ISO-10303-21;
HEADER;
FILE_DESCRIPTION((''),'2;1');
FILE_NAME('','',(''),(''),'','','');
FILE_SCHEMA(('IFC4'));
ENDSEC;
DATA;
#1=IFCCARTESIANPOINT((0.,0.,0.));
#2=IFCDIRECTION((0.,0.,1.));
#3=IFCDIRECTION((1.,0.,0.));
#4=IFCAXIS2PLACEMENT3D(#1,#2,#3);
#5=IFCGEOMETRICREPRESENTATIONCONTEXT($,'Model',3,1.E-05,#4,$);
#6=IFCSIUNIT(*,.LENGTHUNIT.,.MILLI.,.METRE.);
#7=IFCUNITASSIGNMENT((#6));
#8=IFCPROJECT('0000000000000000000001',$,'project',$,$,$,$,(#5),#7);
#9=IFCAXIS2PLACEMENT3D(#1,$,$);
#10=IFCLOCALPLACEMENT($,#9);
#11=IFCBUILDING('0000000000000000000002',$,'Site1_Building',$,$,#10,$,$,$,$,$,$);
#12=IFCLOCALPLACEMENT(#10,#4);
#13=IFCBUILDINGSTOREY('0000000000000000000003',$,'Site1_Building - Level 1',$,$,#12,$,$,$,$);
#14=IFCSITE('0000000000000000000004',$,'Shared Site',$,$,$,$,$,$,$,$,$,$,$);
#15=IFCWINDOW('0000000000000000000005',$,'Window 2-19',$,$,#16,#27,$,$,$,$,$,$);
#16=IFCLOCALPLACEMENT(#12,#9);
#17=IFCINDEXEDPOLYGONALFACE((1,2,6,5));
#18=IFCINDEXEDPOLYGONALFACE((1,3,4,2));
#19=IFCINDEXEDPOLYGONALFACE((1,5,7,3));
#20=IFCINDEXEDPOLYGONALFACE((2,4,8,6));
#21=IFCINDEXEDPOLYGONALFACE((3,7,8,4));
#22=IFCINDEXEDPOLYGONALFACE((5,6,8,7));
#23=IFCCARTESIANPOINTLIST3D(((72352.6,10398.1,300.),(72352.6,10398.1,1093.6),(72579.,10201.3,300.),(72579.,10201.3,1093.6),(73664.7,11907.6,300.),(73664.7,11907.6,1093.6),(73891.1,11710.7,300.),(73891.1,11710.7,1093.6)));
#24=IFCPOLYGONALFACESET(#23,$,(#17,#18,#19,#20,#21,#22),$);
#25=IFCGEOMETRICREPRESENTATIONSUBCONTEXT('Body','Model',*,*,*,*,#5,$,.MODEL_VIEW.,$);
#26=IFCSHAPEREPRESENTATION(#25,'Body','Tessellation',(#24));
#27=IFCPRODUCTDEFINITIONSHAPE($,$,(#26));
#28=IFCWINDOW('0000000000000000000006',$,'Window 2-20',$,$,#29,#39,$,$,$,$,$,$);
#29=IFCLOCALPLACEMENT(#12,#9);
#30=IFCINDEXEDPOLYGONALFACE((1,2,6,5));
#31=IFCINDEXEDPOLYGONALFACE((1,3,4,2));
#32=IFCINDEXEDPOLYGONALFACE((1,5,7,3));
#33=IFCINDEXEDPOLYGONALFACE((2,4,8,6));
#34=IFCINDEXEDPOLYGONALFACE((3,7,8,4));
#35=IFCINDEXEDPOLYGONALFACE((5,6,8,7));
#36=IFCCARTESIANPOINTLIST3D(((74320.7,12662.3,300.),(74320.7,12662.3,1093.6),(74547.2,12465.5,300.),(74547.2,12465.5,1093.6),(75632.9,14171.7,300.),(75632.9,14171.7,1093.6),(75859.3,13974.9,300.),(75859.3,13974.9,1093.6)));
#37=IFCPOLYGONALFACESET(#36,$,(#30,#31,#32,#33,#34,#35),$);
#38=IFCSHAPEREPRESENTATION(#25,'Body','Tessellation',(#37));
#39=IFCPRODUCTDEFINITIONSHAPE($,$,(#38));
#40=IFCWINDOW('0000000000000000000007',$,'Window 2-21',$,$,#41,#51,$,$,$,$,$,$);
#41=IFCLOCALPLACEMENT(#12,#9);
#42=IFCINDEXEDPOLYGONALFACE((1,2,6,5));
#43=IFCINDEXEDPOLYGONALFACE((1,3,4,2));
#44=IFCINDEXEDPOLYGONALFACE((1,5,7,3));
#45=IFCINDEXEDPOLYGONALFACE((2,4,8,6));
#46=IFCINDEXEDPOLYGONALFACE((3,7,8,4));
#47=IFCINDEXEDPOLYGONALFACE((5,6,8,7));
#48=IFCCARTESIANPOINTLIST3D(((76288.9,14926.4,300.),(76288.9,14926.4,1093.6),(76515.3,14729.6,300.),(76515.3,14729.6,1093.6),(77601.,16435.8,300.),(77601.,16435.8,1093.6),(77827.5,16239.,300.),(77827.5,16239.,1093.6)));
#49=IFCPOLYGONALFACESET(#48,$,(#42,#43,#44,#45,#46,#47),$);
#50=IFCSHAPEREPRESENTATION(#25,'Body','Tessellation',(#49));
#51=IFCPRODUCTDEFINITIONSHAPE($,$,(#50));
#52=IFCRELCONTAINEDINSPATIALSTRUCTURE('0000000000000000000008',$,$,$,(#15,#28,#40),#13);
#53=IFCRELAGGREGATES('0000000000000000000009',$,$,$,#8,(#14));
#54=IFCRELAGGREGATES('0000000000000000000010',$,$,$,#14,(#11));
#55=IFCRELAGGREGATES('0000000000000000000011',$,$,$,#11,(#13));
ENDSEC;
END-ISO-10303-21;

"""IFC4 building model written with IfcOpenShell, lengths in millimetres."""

from ifc_helpers import new_model, si_unit, frame, origin, origin_with_axes, place, context, subcontext, project, spatial, indexed_curve, outline, extrude, element, save


model = new_model("IFC4")

# Units and contexts
model_context = context("Model", 3, precision=1e-05, world=origin_with_axes())
body_context = subcontext(model_context, "Body", "Model", "MODEL_VIEW")
ifc_project = project(units=[si_unit("LENGTHUNIT", "METRE", prefix="MILLI")], contexts=[model_context])

# Site, building, storey
site = spatial("IfcSite", under=ifc_project, Name="Shared Site")
building_placement = place(None, origin())
building = spatial("IfcBuilding", under=site, at=building_placement, Name="Site1_Building")
storey_placement = place(building_placement, origin_with_axes())
storey = spatial("IfcBuildingStorey", under=building, at=storey_placement, Name="Site1_Building - Level 1")

# Windows
for number, where, z_axis, x_axis, name in (
    (1, (72579.0, 10201.3, 300.0), (0.0, 0.0, 1.0), (0.656059, 0.75471, 0.0), "Window 2-19"),
    (2, (74547.2, 12465.5, 300.0), (0.0, 0.0, 1.0), (0.656059, 0.75471, 0.0), "Window 2-20"),
    (3, (76515.3, 14729.6, 300.0), (0.0, 0.0, 1.0), (0.656059, 0.75471, 0.0), "Window 2-21"),
):
    element("IfcWindow", number, at=place(storey_placement, frame(where, z_axis=z_axis, x_axis=x_axis)), inside=storey, Name=name, context=body_context, shape_type="SweptSolid", body=[
        extrude(outline(indexed_curve([(0.0, 0.0), (0.0, 300.0), (2000.0, 300.0), (2000.0, 0.0), (0.0, 0.0)], self_intersect=False)), origin_with_axes(), (0.0, 0.0, 1.0), 793.6),
    ])

save(model, "model.ifc")
